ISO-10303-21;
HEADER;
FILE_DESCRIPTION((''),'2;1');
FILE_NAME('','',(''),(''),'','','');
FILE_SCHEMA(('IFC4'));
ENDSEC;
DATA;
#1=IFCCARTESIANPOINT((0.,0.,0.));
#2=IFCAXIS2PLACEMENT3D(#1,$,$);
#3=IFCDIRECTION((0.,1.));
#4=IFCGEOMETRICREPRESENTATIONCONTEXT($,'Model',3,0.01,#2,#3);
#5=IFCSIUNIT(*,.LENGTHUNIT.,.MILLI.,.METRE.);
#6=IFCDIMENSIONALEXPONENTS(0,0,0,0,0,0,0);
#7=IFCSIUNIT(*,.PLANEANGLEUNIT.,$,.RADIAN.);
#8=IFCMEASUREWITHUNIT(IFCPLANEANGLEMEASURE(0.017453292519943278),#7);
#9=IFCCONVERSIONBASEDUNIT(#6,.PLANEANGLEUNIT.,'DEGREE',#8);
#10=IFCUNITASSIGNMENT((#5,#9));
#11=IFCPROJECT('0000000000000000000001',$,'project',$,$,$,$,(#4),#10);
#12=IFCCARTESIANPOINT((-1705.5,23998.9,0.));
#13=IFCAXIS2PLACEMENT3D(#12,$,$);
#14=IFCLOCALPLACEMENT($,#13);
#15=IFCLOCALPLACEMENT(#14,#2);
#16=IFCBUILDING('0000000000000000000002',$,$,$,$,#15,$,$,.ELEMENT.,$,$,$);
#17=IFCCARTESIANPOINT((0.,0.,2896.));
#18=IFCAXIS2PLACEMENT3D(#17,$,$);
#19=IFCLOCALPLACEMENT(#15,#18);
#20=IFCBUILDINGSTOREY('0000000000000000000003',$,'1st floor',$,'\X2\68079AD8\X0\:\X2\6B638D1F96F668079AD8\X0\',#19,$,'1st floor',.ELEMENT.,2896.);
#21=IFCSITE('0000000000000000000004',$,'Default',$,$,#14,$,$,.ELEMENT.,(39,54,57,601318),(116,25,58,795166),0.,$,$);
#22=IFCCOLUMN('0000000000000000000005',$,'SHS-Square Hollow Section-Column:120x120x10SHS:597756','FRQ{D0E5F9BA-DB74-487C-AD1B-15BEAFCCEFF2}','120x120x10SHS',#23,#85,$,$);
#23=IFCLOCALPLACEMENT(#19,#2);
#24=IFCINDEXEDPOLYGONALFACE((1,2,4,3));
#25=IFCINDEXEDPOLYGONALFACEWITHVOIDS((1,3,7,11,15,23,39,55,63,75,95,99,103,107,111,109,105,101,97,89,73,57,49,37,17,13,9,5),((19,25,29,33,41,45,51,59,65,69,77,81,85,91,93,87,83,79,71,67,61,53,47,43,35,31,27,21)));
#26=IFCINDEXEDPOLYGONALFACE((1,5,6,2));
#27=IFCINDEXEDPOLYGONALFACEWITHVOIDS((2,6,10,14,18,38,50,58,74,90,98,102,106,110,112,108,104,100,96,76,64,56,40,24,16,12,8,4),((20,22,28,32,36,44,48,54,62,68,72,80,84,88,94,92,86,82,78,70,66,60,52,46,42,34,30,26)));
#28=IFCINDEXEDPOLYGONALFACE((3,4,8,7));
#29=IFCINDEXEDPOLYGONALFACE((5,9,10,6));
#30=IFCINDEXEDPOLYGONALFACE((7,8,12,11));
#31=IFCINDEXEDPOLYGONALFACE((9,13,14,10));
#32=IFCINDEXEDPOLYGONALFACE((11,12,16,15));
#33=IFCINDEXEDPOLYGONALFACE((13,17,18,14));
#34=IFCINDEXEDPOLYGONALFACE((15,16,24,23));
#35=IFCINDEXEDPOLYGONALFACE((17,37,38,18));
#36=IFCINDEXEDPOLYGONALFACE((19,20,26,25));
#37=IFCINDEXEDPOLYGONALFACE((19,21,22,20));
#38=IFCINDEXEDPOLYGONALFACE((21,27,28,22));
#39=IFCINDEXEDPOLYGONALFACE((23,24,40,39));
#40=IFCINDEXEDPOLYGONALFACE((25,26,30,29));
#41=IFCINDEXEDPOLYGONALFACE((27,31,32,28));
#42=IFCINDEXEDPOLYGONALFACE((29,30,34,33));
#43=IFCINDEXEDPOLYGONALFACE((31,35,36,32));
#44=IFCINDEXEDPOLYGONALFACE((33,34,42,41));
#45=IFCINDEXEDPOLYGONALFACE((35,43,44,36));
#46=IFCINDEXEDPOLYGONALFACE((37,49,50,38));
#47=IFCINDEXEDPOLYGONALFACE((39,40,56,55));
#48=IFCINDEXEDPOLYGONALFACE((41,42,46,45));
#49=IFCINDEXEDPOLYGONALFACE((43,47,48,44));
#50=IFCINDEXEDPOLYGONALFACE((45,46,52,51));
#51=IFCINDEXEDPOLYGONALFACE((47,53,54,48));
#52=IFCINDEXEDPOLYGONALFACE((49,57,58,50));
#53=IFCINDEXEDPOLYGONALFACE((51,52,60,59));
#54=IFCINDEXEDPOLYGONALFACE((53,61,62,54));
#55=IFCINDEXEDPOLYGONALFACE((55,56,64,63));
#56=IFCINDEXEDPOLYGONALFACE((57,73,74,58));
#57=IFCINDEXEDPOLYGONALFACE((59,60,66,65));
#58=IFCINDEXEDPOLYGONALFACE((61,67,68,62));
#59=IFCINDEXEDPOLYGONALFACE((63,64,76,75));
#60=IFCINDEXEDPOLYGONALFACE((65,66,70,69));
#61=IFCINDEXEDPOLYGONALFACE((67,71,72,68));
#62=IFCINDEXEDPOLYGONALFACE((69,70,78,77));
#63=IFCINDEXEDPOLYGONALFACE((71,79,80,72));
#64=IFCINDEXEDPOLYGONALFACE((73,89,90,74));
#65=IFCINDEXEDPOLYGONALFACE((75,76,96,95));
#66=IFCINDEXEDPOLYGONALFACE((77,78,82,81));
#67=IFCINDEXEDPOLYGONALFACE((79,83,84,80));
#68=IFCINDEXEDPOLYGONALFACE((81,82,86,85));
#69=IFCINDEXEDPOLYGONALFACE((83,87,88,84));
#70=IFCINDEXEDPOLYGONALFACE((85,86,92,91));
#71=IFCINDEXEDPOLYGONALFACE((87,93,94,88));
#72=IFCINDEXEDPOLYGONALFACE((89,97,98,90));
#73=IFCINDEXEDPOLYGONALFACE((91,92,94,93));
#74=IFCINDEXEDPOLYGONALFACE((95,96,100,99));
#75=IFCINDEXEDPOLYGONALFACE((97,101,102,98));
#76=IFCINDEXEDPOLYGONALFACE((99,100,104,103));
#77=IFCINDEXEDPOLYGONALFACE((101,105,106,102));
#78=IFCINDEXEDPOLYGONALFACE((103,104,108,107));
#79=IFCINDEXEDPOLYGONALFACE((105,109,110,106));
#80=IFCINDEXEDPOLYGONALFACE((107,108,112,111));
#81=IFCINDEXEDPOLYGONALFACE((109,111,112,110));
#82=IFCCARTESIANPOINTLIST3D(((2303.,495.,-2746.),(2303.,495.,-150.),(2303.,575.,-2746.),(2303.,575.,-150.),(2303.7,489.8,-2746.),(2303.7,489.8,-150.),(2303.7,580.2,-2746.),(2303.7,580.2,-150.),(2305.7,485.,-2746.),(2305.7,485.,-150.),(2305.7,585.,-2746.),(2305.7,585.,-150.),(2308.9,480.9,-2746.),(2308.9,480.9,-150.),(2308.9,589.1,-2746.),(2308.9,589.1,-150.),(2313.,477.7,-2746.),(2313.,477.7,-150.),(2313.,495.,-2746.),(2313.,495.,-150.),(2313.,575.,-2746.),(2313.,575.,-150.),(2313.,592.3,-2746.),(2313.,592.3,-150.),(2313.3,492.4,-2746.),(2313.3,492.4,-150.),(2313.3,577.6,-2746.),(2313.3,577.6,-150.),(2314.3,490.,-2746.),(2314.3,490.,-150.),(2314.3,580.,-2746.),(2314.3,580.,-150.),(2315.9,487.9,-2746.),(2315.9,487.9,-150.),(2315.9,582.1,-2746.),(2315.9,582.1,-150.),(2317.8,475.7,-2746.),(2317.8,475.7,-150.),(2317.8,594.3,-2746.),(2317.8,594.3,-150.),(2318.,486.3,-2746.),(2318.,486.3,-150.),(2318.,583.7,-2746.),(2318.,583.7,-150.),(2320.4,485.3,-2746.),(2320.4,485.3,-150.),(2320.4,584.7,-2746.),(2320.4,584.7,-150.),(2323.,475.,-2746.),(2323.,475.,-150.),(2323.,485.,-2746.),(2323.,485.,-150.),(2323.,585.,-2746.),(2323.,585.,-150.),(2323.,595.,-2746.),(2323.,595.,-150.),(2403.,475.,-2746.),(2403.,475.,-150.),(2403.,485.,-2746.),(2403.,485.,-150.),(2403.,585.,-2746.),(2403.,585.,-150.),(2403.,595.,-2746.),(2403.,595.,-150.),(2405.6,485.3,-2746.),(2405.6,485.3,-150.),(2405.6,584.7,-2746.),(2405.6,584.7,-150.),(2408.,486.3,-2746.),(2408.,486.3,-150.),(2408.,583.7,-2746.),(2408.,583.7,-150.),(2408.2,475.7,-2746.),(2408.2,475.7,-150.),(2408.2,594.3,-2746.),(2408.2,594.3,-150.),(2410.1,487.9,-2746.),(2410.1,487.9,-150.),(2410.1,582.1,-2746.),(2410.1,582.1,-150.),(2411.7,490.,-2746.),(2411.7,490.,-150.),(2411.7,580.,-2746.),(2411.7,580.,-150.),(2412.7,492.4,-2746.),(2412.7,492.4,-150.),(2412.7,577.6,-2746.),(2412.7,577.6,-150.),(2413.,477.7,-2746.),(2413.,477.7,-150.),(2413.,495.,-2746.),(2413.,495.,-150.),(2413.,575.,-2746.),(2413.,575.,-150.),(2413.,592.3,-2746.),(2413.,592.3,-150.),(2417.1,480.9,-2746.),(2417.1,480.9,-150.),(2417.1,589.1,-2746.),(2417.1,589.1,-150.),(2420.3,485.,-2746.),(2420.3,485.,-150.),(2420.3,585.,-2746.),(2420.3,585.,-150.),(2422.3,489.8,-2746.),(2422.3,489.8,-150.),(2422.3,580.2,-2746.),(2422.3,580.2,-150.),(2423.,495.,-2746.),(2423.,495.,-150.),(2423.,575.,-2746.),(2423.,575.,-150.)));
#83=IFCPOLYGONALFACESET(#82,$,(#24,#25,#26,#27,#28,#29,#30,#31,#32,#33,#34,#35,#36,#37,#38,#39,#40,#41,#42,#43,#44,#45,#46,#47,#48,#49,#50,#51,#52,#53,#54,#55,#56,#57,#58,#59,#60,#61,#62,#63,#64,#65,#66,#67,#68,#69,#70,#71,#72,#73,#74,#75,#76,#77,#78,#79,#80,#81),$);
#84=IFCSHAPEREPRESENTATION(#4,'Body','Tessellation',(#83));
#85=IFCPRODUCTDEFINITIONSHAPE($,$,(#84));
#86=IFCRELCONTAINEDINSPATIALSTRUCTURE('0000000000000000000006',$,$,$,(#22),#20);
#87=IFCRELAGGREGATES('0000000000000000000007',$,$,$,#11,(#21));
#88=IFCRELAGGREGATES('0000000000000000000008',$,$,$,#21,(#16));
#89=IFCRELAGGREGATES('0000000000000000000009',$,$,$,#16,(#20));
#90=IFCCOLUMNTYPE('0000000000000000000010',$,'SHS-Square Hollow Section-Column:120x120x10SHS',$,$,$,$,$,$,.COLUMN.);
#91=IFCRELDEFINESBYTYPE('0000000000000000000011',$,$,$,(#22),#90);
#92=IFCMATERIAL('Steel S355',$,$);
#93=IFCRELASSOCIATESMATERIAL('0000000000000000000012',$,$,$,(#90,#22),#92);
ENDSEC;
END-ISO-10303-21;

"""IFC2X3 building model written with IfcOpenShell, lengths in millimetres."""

from ifc_helpers import new_model, entity, si_unit, converted_unit, direction, frame, origin, origin_2d, place, context, project, spatial, hollow_rectangle, extrude, clip, halfspace, material, type_object, element, save


model = new_model("IFC2X3")

# Units and contexts
model_context = context("Model", 3, precision=0.01, world=origin(), true_north=direction((0.0, 1.0)))
ifc_project = project(units=[si_unit("LENGTHUNIT", "METRE", prefix="MILLI"), converted_unit("PLANEANGLEUNIT", "DEGREE", entity("IfcPlaneAngleMeasure", 0.017453292519943278), si_unit("PLANEANGLEUNIT", "RADIAN"), dimensions=[0, 0, 0, 0, 0, 0, 0])], contexts=[model_context])

# Site, building, storey
site_placement = place(None, frame((-1705.5, 23998.9, 0.0)))
site = spatial("IfcSite", under=ifc_project, at=site_placement, Name="Default", CompositionType="ELEMENT", RefLatitude=(39, 54, 57, 601318), RefLongitude=(116, 25, 58, 795166), RefElevation=0.0)
building_placement = place(site_placement, origin())
building = spatial("IfcBuilding", under=site, at=building_placement, CompositionType="ELEMENT")
storey_placement = place(building_placement, frame((0.0, 0.0, 2896.0)))
storey = spatial("IfcBuildingStorey", under=building, at=storey_placement, Name="1st floor", ObjectType="标高:正负零标高", LongName="1st floor", CompositionType="ELEMENT", Elevation=2896.0)

# Shared definitions
ifc_material_1 = material(Name="Steel S355")

# Column
column_type_1 = type_object("IfcColumnType", Name="SHS-Square Hollow Section-Column:120x120x10SHS", PredefinedType="COLUMN", material=ifc_material_1)
column_1_placement = place(storey_placement, frame((2363.0, 535.0, -150.0), z_axis=(0.0, 0.0, 1.0), x_axis=(0.0, -1.0, 0.0)))
element("IfcColumn", 1, at=column_1_placement, inside=storey, type_object=column_type_1, material=ifc_material_1, Name="SHS-Square Hollow Section-Column:120x120x10SHS:597756", Description="FRQ{D0E5F9BA-DB74-487C-AD1B-15BEAFCCEFF2}", ObjectType="120x120x10SHS", context=model_context, shape_type="Clipping", body=[
    clip(extrude(hollow_rectangle(XDim=120.0, YDim=120.0, WallThickness=10.0, InnerFilletRadius=10.0, OuterFilletRadius=20.0, at=origin_2d()), origin(), (0.0, 0.0, -1.0), 2680.9), halfspace(frame((535.0, -2363.0, -2596.0), z_axis=(0.0, 0.0, 1.0), x_axis=(0.0, 1.0, 0.0)), True)),
])

save(model, "model.ifc")
